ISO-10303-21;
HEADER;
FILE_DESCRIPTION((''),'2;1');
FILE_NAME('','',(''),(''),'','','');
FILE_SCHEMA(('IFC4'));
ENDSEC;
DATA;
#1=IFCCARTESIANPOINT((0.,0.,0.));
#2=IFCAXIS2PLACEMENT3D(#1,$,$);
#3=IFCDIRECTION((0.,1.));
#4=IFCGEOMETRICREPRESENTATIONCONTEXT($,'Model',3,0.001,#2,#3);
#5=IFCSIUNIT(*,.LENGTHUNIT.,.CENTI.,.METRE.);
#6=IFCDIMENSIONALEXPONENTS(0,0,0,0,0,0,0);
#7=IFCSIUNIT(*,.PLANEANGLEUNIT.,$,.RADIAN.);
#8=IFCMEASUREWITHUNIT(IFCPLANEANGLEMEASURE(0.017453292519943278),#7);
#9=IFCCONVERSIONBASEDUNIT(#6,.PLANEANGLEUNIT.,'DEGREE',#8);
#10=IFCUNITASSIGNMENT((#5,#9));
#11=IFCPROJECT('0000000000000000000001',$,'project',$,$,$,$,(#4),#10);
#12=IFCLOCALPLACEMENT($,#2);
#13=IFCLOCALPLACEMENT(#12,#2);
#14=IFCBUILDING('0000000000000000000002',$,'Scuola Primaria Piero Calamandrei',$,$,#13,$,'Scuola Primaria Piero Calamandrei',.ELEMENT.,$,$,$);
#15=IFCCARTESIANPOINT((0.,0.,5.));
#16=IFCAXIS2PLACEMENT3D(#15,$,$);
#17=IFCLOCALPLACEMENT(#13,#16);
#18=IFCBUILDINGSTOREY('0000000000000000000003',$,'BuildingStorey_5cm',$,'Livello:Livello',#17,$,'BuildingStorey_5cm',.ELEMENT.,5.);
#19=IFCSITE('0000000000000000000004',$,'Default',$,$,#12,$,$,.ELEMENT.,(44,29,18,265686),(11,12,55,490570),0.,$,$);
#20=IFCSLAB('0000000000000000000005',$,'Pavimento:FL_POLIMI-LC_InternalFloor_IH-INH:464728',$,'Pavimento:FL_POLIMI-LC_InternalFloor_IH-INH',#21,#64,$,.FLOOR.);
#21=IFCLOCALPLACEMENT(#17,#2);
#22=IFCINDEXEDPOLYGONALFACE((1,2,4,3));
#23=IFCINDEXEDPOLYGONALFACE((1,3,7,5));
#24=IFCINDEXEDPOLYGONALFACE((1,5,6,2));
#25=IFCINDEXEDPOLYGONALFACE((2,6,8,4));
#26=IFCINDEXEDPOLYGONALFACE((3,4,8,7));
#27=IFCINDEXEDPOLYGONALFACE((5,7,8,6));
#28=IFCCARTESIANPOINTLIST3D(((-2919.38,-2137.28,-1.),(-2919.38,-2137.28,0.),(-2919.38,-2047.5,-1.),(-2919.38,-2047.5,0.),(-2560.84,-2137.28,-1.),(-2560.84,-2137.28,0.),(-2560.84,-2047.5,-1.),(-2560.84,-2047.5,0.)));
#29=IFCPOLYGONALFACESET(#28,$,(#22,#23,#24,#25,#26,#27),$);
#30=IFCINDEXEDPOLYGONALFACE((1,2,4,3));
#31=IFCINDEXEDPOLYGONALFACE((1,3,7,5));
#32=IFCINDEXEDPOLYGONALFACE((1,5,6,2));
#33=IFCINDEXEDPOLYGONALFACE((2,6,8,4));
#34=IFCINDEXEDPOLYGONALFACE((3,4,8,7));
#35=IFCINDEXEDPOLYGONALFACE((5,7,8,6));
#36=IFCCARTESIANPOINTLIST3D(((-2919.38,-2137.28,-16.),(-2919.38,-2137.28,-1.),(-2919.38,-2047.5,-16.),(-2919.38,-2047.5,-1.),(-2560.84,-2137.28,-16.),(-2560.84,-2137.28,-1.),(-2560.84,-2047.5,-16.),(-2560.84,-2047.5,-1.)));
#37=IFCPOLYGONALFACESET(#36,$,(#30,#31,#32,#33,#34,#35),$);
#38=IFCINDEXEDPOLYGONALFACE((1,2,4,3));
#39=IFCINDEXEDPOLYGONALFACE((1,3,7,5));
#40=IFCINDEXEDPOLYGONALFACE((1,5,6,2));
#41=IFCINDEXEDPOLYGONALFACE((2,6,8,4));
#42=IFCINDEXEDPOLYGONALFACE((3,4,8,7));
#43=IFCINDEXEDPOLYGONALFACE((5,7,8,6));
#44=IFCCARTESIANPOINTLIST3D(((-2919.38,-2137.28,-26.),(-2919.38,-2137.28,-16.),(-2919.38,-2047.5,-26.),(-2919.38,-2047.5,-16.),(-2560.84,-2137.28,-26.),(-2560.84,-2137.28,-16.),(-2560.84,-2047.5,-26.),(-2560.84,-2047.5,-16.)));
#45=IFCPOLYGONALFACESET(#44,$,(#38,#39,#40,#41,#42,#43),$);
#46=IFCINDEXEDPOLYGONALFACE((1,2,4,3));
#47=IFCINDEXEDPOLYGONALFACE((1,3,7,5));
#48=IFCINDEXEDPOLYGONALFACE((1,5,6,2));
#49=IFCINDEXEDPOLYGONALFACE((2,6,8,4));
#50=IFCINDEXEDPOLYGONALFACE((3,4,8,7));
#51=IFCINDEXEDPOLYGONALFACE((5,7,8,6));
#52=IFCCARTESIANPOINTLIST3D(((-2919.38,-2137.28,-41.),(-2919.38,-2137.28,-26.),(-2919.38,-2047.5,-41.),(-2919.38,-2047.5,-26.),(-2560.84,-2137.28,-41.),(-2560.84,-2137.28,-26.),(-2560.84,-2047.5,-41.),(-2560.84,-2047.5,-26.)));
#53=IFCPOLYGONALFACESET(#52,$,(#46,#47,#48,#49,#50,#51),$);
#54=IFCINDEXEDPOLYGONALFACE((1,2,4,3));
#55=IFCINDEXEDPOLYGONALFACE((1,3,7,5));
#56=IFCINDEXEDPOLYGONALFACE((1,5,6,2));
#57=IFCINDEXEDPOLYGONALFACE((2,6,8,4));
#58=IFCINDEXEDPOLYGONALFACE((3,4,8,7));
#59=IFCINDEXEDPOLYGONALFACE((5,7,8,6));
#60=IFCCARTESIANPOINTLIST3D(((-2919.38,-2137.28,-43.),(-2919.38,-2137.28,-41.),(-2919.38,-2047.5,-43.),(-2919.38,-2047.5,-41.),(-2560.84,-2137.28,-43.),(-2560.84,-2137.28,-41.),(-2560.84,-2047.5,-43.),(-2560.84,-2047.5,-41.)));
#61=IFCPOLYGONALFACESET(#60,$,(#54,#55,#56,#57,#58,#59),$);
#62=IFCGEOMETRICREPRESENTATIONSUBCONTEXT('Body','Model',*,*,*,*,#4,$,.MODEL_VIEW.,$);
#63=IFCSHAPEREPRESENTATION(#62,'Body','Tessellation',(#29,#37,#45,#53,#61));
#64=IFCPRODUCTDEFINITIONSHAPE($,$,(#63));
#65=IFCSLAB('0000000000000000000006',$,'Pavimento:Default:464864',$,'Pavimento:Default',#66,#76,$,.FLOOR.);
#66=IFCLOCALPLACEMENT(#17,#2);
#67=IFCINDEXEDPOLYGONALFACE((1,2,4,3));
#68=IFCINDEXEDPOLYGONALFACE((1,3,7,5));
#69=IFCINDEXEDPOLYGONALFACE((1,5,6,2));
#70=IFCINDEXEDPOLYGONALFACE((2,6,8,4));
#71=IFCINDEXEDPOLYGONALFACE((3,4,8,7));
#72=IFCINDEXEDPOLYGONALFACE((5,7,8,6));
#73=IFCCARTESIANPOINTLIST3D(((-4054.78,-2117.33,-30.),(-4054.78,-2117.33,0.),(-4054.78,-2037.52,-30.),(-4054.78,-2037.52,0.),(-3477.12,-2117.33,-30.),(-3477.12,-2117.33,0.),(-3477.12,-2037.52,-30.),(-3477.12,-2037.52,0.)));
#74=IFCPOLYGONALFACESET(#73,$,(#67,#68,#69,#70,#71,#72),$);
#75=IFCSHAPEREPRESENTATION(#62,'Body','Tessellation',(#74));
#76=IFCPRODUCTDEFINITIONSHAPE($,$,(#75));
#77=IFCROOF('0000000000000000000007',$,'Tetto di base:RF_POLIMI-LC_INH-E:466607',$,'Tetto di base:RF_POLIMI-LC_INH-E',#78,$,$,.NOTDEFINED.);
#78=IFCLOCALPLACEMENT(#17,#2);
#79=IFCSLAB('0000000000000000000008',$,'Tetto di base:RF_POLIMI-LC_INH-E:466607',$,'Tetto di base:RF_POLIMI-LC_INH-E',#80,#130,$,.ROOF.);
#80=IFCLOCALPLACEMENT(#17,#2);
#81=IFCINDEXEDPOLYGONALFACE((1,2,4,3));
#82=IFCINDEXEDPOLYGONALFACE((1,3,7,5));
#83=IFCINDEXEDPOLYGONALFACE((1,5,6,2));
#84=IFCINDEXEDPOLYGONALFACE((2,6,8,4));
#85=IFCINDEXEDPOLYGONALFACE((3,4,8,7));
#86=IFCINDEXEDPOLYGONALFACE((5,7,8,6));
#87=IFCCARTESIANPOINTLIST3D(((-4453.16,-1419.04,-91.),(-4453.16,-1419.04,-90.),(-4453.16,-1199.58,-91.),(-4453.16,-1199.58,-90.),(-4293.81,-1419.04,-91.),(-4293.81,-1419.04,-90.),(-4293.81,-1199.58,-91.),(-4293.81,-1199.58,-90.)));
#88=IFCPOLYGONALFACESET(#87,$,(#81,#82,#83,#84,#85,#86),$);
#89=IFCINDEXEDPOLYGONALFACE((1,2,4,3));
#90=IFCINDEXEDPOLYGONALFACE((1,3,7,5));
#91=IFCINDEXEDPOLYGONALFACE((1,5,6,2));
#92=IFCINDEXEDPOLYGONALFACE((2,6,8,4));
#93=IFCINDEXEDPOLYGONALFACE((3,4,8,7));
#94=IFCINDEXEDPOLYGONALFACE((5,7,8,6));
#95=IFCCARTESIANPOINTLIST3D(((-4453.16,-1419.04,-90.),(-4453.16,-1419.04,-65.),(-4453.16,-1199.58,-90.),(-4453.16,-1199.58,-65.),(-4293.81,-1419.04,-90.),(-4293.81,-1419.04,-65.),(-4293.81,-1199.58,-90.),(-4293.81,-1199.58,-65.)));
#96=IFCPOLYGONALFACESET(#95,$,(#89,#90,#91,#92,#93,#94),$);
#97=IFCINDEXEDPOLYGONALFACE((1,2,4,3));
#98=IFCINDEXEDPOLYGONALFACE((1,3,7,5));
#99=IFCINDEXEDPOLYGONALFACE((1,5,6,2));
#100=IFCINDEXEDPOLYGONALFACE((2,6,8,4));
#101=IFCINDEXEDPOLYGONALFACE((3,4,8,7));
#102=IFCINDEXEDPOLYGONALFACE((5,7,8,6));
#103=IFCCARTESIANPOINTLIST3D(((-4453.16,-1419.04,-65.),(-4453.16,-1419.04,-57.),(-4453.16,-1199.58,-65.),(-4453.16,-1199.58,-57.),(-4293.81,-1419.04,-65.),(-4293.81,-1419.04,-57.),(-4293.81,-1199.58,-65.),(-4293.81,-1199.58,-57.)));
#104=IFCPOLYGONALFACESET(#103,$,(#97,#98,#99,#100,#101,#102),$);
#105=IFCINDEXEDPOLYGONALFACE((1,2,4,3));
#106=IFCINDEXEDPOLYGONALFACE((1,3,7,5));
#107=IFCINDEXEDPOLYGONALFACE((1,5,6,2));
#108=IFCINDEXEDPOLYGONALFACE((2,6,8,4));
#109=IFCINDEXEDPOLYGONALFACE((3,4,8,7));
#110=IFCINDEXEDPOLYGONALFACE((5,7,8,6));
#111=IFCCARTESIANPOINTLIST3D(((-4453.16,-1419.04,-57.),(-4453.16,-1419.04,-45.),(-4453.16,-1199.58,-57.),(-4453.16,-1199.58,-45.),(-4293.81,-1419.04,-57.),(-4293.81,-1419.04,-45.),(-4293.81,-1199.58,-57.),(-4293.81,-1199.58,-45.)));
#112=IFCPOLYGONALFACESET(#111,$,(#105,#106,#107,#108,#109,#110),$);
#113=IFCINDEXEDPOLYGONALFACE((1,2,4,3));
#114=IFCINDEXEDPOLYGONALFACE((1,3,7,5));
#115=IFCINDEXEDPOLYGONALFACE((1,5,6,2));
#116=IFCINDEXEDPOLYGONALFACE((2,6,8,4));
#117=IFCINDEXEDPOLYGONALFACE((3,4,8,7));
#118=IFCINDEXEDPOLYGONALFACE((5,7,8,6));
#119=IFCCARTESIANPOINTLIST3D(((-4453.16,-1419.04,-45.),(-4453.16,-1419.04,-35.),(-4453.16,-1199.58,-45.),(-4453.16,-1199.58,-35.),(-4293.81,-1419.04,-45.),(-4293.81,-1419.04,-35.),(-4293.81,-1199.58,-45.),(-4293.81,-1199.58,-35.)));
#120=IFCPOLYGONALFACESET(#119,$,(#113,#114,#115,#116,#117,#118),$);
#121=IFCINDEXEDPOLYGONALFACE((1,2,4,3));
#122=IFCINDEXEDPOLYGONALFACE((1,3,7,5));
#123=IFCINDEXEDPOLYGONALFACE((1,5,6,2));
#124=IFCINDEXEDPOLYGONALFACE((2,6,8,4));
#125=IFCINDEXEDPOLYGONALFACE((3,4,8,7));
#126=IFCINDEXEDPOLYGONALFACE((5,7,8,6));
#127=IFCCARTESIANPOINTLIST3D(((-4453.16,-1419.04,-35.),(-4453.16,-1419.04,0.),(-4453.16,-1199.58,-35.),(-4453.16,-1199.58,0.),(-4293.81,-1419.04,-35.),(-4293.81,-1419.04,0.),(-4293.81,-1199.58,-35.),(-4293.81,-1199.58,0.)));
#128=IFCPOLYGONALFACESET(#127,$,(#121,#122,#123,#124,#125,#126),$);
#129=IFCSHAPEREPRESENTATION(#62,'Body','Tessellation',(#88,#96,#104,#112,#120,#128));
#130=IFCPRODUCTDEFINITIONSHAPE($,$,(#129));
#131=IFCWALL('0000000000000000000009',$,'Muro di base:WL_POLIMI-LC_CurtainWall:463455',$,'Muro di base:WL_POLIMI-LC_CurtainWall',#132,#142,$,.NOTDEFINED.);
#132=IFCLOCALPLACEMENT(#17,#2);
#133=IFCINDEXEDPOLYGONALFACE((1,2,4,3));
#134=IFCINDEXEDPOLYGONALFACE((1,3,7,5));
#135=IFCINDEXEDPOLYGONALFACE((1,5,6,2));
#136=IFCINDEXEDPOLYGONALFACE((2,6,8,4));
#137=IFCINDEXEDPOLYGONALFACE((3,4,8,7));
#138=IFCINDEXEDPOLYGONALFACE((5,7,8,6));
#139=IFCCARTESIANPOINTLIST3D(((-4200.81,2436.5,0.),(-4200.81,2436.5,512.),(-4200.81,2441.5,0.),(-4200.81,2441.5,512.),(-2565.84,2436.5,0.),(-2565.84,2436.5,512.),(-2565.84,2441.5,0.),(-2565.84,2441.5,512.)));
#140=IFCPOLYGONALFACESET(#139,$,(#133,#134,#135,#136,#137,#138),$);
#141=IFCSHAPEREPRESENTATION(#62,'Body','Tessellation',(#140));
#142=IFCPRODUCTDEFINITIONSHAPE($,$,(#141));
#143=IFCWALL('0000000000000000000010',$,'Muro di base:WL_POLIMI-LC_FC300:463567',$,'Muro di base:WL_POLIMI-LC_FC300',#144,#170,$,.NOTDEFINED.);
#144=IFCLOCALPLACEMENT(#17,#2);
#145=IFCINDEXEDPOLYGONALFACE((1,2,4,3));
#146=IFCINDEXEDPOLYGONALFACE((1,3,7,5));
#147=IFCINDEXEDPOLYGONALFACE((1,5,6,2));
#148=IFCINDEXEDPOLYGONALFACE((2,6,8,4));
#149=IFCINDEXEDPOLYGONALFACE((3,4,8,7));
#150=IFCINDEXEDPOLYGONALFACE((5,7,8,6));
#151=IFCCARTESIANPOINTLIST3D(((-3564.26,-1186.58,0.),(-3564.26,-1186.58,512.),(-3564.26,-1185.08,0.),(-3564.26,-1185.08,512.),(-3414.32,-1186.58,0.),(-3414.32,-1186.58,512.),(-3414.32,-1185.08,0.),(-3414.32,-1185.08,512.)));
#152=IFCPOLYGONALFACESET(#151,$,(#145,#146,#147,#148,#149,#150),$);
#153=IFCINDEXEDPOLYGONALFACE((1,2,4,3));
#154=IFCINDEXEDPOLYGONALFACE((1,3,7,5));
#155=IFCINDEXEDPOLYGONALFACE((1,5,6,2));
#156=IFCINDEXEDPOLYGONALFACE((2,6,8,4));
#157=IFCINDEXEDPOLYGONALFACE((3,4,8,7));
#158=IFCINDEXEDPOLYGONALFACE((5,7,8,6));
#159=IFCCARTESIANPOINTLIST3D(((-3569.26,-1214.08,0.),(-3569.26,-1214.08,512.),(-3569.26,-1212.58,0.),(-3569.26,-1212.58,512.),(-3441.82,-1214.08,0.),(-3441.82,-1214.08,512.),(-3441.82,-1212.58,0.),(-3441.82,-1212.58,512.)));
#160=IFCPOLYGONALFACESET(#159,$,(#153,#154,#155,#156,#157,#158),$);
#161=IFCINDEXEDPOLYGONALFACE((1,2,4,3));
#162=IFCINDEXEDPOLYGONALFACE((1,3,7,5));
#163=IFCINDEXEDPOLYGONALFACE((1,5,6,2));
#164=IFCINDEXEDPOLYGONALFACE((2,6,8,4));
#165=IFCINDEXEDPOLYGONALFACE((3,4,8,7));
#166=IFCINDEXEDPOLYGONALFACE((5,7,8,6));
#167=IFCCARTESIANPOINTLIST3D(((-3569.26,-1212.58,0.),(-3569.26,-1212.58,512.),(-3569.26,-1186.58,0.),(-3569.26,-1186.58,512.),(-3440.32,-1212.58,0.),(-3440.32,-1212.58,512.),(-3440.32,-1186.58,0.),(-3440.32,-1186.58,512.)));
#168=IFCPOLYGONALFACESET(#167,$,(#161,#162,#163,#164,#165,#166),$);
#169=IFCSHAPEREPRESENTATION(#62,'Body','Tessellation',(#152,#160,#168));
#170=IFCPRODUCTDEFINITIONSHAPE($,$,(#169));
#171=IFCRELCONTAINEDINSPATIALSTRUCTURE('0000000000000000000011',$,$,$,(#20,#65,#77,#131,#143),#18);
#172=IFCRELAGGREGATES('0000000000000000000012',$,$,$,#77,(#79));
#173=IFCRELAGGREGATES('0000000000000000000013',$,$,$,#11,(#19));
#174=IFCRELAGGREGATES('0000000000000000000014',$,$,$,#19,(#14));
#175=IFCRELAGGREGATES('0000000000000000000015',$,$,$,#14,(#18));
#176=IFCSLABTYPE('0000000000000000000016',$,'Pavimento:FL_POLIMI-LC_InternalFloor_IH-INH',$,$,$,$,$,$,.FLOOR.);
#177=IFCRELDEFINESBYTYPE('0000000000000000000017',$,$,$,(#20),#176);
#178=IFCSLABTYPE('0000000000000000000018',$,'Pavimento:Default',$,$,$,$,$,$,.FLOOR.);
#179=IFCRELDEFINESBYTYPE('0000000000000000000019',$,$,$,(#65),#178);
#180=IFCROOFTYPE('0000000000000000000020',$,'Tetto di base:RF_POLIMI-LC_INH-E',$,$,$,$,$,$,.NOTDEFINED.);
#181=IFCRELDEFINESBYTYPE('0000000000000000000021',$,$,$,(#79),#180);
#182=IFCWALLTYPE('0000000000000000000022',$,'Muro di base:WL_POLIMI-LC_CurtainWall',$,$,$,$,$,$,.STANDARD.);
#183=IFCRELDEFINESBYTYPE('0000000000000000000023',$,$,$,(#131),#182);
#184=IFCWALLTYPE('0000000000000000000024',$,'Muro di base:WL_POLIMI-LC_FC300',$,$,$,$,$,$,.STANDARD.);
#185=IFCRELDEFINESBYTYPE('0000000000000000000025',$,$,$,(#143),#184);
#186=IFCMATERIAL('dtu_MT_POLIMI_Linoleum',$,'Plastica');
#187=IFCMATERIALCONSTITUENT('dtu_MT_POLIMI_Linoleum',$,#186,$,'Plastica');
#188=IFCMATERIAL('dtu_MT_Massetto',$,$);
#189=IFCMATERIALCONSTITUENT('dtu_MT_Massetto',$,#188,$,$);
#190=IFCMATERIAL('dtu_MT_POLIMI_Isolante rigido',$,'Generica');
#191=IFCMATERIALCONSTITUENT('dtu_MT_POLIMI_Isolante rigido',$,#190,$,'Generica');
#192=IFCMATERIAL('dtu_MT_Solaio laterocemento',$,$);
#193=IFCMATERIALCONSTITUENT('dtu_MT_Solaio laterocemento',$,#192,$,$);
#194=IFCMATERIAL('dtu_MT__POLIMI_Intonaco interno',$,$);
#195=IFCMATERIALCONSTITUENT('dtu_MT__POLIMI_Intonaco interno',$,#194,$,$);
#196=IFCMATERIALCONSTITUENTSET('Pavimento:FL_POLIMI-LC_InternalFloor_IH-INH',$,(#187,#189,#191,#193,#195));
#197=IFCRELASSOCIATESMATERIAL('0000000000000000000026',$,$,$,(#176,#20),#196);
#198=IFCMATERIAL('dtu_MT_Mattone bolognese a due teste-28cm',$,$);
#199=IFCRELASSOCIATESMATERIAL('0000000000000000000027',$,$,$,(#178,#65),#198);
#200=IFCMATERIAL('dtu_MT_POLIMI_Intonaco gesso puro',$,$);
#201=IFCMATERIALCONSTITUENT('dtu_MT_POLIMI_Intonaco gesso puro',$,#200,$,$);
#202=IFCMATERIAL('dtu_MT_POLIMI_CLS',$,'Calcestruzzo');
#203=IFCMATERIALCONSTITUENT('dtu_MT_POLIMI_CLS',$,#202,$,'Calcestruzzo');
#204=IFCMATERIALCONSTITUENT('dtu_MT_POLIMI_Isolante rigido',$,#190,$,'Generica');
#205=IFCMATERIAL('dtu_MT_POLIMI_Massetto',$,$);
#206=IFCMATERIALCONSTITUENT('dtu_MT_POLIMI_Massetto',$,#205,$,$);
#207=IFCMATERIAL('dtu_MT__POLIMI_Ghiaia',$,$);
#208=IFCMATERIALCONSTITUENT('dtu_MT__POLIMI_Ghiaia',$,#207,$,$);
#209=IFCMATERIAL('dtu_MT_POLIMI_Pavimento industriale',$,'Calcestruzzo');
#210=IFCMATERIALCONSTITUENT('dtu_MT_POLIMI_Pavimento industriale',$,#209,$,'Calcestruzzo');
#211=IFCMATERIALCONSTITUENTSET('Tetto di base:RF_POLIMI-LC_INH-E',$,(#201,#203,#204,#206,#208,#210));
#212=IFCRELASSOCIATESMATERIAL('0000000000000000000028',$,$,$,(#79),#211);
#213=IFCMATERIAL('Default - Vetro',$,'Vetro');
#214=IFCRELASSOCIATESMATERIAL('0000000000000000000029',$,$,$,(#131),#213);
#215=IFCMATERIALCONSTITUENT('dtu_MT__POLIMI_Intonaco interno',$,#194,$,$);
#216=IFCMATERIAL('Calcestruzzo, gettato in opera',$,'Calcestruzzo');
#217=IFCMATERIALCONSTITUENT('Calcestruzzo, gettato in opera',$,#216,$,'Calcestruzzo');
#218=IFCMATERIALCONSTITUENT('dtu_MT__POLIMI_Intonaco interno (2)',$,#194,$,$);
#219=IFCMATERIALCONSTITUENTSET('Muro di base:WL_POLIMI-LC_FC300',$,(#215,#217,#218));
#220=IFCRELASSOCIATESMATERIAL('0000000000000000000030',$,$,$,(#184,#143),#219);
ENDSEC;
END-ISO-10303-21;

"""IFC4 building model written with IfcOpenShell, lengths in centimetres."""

from ifc_helpers import new_model, entity, si_unit, converted_unit, direction, frame, origin, place, context, subcontext, project, spatial, indexed_curve, outline, extrude, material, constituent, constituent_set, type_object, element, aggregate, save


model = new_model("IFC4")

# Units and contexts
model_context = context("Model", 3, precision=0.001, world=origin(), true_north=direction((0.0, 1.0)))
body_context = subcontext(model_context, "Body", "Model", "MODEL_VIEW")
ifc_project = project(units=[si_unit("LENGTHUNIT", "METRE", prefix="CENTI"), converted_unit("PLANEANGLEUNIT", "DEGREE", entity("IfcPlaneAngleMeasure", 0.017453292519943278), si_unit("PLANEANGLEUNIT", "RADIAN"), dimensions=[0, 0, 0, 0, 0, 0, 0])], contexts=[model_context])

# Site, building, storey
site_placement = place(None, origin())
site = spatial("IfcSite", under=ifc_project, at=site_placement, Name="Default", CompositionType="ELEMENT", RefLatitude=(44, 29, 18, 265686), RefLongitude=(11, 12, 55, 490570), RefElevation=0.0)
building_placement = place(site_placement, origin())
building = spatial("IfcBuilding", under=site, at=building_placement, Name="Scuola Primaria Piero Calamandrei", LongName="Scuola Primaria Piero Calamandrei", CompositionType="ELEMENT")
storey_placement = place(building_placement, frame((0.0, 0.0, 5.0)))
storey = spatial("IfcBuildingStorey", under=building, at=storey_placement, Name="BuildingStorey_5cm", ObjectType="Livello:Livello", LongName="BuildingStorey_5cm", CompositionType="ELEMENT", Elevation=5.0)

# Slabs
ifc_material_1 = material(Name="dtu_MT_POLIMI_Linoleum", Category="Plastica")
ifc_constituent_1 = constituent(ifc_material_1, Name="dtu_MT_POLIMI_Linoleum", Category="Plastica")
ifc_material_2 = material(Name="dtu_MT_Massetto")
ifc_constituent_2 = constituent(ifc_material_2, Name="dtu_MT_Massetto")
ifc_material_3 = material(Name="dtu_MT_POLIMI_Isolante rigido", Category="Generica")
ifc_constituent_3 = constituent(ifc_material_3, Name="dtu_MT_POLIMI_Isolante rigido", Category="Generica")
ifc_material_4 = material(Name="dtu_MT_Solaio laterocemento")
ifc_constituent_4 = constituent(ifc_material_4, Name="dtu_MT_Solaio laterocemento")
ifc_material_5 = material(Name="dtu_MT__POLIMI_Intonaco interno")
ifc_constituent_5 = constituent(ifc_material_5, Name="dtu_MT__POLIMI_Intonaco interno")
ifc_constituent_set_1 = constituent_set(constituents=[ifc_constituent_1, ifc_constituent_2, ifc_constituent_3, ifc_constituent_4, ifc_constituent_5], Name="Pavimento:FL_POLIMI-LC_InternalFloor_IH-INH")
slab_type_1 = type_object("IfcSlabType", Name="Pavimento:FL_POLIMI-LC_InternalFloor_IH-INH", PredefinedType="FLOOR", material=ifc_constituent_set_1)
slab_1_placement = place(storey_placement, origin())
element("IfcSlab", 1, at=slab_1_placement, inside=storey, type_object=slab_type_1, material=ifc_constituent_set_1, Name="Pavimento:FL_POLIMI-LC_InternalFloor_IH-INH:464728", ObjectType="Pavimento:FL_POLIMI-LC_InternalFloor_IH-INH", PredefinedType="FLOOR", context=body_context, shape_type="SweptSolid", body=[
    extrude(outline(indexed_curve([(-44.89, -179.27), (44.89, -179.27), (44.89, 179.27), (-44.89, 179.27), (-44.89, -179.27)], self_intersect=False)), frame((-2740.11, -2092.39, -1.0), z_axis=(0.0, 0.0, 1.0), x_axis=(0.0, 1.0, 0.0)), (0.0, 0.0, 1.0), 1.0),
    extrude(outline(indexed_curve([(-44.89, -179.27), (44.89, -179.27), (44.89, 179.27), (-44.89, 179.27), (-44.89, -179.27)], self_intersect=False)), frame((-2740.11, -2092.39, -16.0), z_axis=(0.0, 0.0, 1.0), x_axis=(0.0, 1.0, 0.0)), (0.0, 0.0, 1.0), 15.0),
    extrude(outline(indexed_curve([(-44.89, -179.27), (44.89, -179.27), (44.89, 179.27), (-44.89, 179.27), (-44.89, -179.27)], self_intersect=False)), frame((-2740.11, -2092.39, -26.0), z_axis=(0.0, 0.0, 1.0), x_axis=(0.0, 1.0, 0.0)), (0.0, 0.0, 1.0), 10.0),
    extrude(outline(indexed_curve([(-44.89, -179.27), (44.89, -179.27), (44.89, 179.27), (-44.89, 179.27), (-44.89, -179.27)], self_intersect=False)), frame((-2740.11, -2092.39, -41.0), z_axis=(0.0, 0.0, 1.0), x_axis=(0.0, 1.0, 0.0)), (0.0, 0.0, 1.0), 15.0),
    extrude(outline(indexed_curve([(-44.89, -179.27), (44.89, -179.27), (44.89, 179.27), (-44.89, 179.27), (-44.89, -179.27)], self_intersect=False)), frame((-2740.11, -2092.39, -43.0), z_axis=(0.0, 0.0, 1.0), x_axis=(0.0, 1.0, 0.0)), (0.0, 0.0, 1.0), 2.0),
])
ifc_material_6 = material(Name="dtu_MT_Mattone bolognese a due teste-28cm")
slab_type_2 = type_object("IfcSlabType", Name="Pavimento:Default", PredefinedType="FLOOR", material=ifc_material_6)
slab_2_placement = place(storey_placement, origin())
element("IfcSlab", 2, at=slab_2_placement, inside=storey, type_object=slab_type_2, material=ifc_material_6, Name="Pavimento:Default:464864", ObjectType="Pavimento:Default", PredefinedType="FLOOR", context=body_context, shape_type="SweptSolid", body=[
    extrude(outline(indexed_curve([(-39.9, -288.83), (39.9, -288.83), (39.9, 288.83), (-39.9, 288.83), (-39.9, -288.83)], self_intersect=False)), frame((-3765.95, -2077.42, 0.0), z_axis=(0.0, 0.0, -1.0), x_axis=(0.0, 1.0, 0.0)), (0.0, 0.0, 1.0), 30.0),
])

# Roof, slab
ifc_material_7 = material(Name="dtu_MT_POLIMI_Intonaco gesso puro")
ifc_constituent_6 = constituent(ifc_material_7, Name="dtu_MT_POLIMI_Intonaco gesso puro")
ifc_material_8 = material(Name="dtu_MT_POLIMI_CLS", Category="Calcestruzzo")
ifc_constituent_7 = constituent(ifc_material_8, Name="dtu_MT_POLIMI_CLS", Category="Calcestruzzo")
ifc_constituent_8 = constituent(ifc_material_3, Name="dtu_MT_POLIMI_Isolante rigido", Category="Generica")
ifc_material_9 = material(Name="dtu_MT_POLIMI_Massetto")
ifc_constituent_9 = constituent(ifc_material_9, Name="dtu_MT_POLIMI_Massetto")
ifc_material_10 = material(Name="dtu_MT__POLIMI_Ghiaia")
ifc_constituent_10 = constituent(ifc_material_10, Name="dtu_MT__POLIMI_Ghiaia")
ifc_material_11 = material(Name="dtu_MT_POLIMI_Pavimento industriale", Category="Calcestruzzo")
ifc_constituent_11 = constituent(ifc_material_11, Name="dtu_MT_POLIMI_Pavimento industriale", Category="Calcestruzzo")
ifc_constituent_set_2 = constituent_set(constituents=[ifc_constituent_6, ifc_constituent_7, ifc_constituent_8, ifc_constituent_9, ifc_constituent_10, ifc_constituent_11], Name="Tetto di base:RF_POLIMI-LC_INH-E")
roof_type = type_object("IfcRoofType", Name="Tetto di base:RF_POLIMI-LC_INH-E", PredefinedType="NOTDEFINED")
roof_1_placement = place(storey_placement, frame((-4453.16, -1419.04, -91.0)))
roof_1 = element("IfcRoof", 3, at=roof_1_placement, inside=storey, Name="Tetto di base:RF_POLIMI-LC_INH-E:466607", ObjectType="Tetto di base:RF_POLIMI-LC_INH-E", PredefinedType="NOTDEFINED")
slab_3_placement = place(roof_1_placement, origin())
slab_3 = element("IfcSlab", 4, at=slab_3_placement, type_object=roof_type, material=ifc_constituent_set_2, Name="Tetto di base:RF_POLIMI-LC_INH-E:466607", ObjectType="Tetto di base:RF_POLIMI-LC_INH-E", PredefinedType="ROOF", context=body_context, shape_type="SweptSolid", body=[
    extrude(outline(indexed_curve([(79.68, -109.73), (79.68, 109.73), (-79.68, 109.73), (-79.68, -109.73), (79.68, -109.73)], self_intersect=False)), frame((79.68, 109.73, 0.0)), (0.0, 0.0, 1.0), 1.0),
    extrude(outline(indexed_curve([(79.68, -109.73), (79.68, 109.73), (-79.68, 109.73), (-79.68, -109.73), (79.68, -109.73)], self_intersect=False)), frame((79.68, 109.73, 1.0)), (0.0, 0.0, 1.0), 25.0),
    extrude(outline(indexed_curve([(79.68, -109.73), (79.68, 109.73), (-79.68, 109.73), (-79.68, -109.73), (79.68, -109.73)], self_intersect=False)), frame((79.68, 109.73, 26.0)), (0.0, 0.0, 1.0), 8.0),
    extrude(outline(indexed_curve([(79.68, -109.73), (79.68, 109.73), (-79.68, 109.73), (-79.68, -109.73), (79.68, -109.73)], self_intersect=False)), frame((79.68, 109.73, 34.0)), (0.0, 0.0, 1.0), 12.0),
    extrude(outline(indexed_curve([(79.68, -109.73), (79.68, 109.73), (-79.68, 109.73), (-79.68, -109.73), (79.68, -109.73)], self_intersect=False)), frame((79.68, 109.73, 46.0)), (0.0, 0.0, 1.0), 10.0),
    extrude(outline(indexed_curve([(79.68, -109.73), (79.68, 109.73), (-79.68, 109.73), (-79.68, -109.73), (79.68, -109.73)], self_intersect=False)), frame((79.68, 109.73, 56.0)), (0.0, 0.0, 1.0), 35.0),
])
aggregate(roof_1, [slab_3])

# Walls
ifc_material_12 = material(Name="Default - Vetro", Category="Vetro")
wall_type_1 = type_object("IfcWallType", Name="Muro di base:WL_POLIMI-LC_CurtainWall", PredefinedType="STANDARD")
wall_1_placement = place(storey_placement, frame((-4200.81, 2439.0, 0.0)))
element("IfcWall", 5, at=wall_1_placement, inside=storey, type_object=wall_type_1, material=ifc_material_12, Name="Muro di base:WL_POLIMI-LC_CurtainWall:463455", ObjectType="Muro di base:WL_POLIMI-LC_CurtainWall", PredefinedType="NOTDEFINED", context=body_context, shape_type="SweptSolid", body=[
    extrude(outline(indexed_curve([(1634.97, 2.5), (0.0, 2.5), (0.0, -2.5), (1634.97, -2.5), (1634.97, 2.5)], self_intersect=False)), origin(), (0.0, 0.0, 1.0), 512.0),
])
ifc_constituent_12 = constituent(ifc_material_5, Name="dtu_MT__POLIMI_Intonaco interno")
ifc_material_13 = material(Name="Calcestruzzo, gettato in opera", Category="Calcestruzzo")
ifc_constituent_13 = constituent(ifc_material_13, Name="Calcestruzzo, gettato in opera", Category="Calcestruzzo")
ifc_constituent_14 = constituent(ifc_material_5, Name="dtu_MT__POLIMI_Intonaco interno (2)")
ifc_constituent_set_3 = constituent_set(constituents=[ifc_constituent_12, ifc_constituent_13, ifc_constituent_14], Name="Muro di base:WL_POLIMI-LC_FC300")
wall_type_2 = type_object("IfcWallType", Name="Muro di base:WL_POLIMI-LC_FC300", PredefinedType="STANDARD", material=ifc_constituent_set_3)
wall_2_placement = place(storey_placement, frame((-3441.82, -1199.58, 0.0), z_axis=(0.0, 0.0, 1.0), x_axis=(-1.0, 0.0, 0.0)))
element("IfcWall", 6, at=wall_2_placement, inside=storey, type_object=wall_type_2, material=ifc_constituent_set_3, Name="Muro di base:WL_POLIMI-LC_FC300:463567", ObjectType="Muro di base:WL_POLIMI-LC_FC300", PredefinedType="NOTDEFINED", context=body_context, shape_type="SweptSolid", body=[
    extrude(outline(indexed_curve([(-0.75, -74.97), (0.75, -74.97), (0.75, 74.97), (-0.75, 74.97), (-0.75, -74.97)], self_intersect=False)), frame((47.47, -13.75, 0.0), z_axis=(0.0, 0.0, 1.0), x_axis=(0.0, 1.0, 0.0)), (0.0, 0.0, 1.0), 512.0),
    extrude(outline(indexed_curve([(-0.75, -63.72), (0.75, -63.72), (0.75, 63.72), (-0.75, 63.72), (-0.75, -63.72)], self_intersect=False)), frame((63.72, 13.75, 0.0), z_axis=(0.0, 0.0, 1.0), x_axis=(0.0, -1.0, 0.0)), (0.0, 0.0, 1.0), 512.0),
    extrude(outline(indexed_curve([(-64.47, -13.0), (64.47, -13.0), (64.47, 13.0), (-64.47, 13.0), (-64.47, -13.0)], self_intersect=False)), frame((62.97, 0.0, 0.0)), (0.0, 0.0, 1.0), 512.0),
])

save(model, "model.ifc")
